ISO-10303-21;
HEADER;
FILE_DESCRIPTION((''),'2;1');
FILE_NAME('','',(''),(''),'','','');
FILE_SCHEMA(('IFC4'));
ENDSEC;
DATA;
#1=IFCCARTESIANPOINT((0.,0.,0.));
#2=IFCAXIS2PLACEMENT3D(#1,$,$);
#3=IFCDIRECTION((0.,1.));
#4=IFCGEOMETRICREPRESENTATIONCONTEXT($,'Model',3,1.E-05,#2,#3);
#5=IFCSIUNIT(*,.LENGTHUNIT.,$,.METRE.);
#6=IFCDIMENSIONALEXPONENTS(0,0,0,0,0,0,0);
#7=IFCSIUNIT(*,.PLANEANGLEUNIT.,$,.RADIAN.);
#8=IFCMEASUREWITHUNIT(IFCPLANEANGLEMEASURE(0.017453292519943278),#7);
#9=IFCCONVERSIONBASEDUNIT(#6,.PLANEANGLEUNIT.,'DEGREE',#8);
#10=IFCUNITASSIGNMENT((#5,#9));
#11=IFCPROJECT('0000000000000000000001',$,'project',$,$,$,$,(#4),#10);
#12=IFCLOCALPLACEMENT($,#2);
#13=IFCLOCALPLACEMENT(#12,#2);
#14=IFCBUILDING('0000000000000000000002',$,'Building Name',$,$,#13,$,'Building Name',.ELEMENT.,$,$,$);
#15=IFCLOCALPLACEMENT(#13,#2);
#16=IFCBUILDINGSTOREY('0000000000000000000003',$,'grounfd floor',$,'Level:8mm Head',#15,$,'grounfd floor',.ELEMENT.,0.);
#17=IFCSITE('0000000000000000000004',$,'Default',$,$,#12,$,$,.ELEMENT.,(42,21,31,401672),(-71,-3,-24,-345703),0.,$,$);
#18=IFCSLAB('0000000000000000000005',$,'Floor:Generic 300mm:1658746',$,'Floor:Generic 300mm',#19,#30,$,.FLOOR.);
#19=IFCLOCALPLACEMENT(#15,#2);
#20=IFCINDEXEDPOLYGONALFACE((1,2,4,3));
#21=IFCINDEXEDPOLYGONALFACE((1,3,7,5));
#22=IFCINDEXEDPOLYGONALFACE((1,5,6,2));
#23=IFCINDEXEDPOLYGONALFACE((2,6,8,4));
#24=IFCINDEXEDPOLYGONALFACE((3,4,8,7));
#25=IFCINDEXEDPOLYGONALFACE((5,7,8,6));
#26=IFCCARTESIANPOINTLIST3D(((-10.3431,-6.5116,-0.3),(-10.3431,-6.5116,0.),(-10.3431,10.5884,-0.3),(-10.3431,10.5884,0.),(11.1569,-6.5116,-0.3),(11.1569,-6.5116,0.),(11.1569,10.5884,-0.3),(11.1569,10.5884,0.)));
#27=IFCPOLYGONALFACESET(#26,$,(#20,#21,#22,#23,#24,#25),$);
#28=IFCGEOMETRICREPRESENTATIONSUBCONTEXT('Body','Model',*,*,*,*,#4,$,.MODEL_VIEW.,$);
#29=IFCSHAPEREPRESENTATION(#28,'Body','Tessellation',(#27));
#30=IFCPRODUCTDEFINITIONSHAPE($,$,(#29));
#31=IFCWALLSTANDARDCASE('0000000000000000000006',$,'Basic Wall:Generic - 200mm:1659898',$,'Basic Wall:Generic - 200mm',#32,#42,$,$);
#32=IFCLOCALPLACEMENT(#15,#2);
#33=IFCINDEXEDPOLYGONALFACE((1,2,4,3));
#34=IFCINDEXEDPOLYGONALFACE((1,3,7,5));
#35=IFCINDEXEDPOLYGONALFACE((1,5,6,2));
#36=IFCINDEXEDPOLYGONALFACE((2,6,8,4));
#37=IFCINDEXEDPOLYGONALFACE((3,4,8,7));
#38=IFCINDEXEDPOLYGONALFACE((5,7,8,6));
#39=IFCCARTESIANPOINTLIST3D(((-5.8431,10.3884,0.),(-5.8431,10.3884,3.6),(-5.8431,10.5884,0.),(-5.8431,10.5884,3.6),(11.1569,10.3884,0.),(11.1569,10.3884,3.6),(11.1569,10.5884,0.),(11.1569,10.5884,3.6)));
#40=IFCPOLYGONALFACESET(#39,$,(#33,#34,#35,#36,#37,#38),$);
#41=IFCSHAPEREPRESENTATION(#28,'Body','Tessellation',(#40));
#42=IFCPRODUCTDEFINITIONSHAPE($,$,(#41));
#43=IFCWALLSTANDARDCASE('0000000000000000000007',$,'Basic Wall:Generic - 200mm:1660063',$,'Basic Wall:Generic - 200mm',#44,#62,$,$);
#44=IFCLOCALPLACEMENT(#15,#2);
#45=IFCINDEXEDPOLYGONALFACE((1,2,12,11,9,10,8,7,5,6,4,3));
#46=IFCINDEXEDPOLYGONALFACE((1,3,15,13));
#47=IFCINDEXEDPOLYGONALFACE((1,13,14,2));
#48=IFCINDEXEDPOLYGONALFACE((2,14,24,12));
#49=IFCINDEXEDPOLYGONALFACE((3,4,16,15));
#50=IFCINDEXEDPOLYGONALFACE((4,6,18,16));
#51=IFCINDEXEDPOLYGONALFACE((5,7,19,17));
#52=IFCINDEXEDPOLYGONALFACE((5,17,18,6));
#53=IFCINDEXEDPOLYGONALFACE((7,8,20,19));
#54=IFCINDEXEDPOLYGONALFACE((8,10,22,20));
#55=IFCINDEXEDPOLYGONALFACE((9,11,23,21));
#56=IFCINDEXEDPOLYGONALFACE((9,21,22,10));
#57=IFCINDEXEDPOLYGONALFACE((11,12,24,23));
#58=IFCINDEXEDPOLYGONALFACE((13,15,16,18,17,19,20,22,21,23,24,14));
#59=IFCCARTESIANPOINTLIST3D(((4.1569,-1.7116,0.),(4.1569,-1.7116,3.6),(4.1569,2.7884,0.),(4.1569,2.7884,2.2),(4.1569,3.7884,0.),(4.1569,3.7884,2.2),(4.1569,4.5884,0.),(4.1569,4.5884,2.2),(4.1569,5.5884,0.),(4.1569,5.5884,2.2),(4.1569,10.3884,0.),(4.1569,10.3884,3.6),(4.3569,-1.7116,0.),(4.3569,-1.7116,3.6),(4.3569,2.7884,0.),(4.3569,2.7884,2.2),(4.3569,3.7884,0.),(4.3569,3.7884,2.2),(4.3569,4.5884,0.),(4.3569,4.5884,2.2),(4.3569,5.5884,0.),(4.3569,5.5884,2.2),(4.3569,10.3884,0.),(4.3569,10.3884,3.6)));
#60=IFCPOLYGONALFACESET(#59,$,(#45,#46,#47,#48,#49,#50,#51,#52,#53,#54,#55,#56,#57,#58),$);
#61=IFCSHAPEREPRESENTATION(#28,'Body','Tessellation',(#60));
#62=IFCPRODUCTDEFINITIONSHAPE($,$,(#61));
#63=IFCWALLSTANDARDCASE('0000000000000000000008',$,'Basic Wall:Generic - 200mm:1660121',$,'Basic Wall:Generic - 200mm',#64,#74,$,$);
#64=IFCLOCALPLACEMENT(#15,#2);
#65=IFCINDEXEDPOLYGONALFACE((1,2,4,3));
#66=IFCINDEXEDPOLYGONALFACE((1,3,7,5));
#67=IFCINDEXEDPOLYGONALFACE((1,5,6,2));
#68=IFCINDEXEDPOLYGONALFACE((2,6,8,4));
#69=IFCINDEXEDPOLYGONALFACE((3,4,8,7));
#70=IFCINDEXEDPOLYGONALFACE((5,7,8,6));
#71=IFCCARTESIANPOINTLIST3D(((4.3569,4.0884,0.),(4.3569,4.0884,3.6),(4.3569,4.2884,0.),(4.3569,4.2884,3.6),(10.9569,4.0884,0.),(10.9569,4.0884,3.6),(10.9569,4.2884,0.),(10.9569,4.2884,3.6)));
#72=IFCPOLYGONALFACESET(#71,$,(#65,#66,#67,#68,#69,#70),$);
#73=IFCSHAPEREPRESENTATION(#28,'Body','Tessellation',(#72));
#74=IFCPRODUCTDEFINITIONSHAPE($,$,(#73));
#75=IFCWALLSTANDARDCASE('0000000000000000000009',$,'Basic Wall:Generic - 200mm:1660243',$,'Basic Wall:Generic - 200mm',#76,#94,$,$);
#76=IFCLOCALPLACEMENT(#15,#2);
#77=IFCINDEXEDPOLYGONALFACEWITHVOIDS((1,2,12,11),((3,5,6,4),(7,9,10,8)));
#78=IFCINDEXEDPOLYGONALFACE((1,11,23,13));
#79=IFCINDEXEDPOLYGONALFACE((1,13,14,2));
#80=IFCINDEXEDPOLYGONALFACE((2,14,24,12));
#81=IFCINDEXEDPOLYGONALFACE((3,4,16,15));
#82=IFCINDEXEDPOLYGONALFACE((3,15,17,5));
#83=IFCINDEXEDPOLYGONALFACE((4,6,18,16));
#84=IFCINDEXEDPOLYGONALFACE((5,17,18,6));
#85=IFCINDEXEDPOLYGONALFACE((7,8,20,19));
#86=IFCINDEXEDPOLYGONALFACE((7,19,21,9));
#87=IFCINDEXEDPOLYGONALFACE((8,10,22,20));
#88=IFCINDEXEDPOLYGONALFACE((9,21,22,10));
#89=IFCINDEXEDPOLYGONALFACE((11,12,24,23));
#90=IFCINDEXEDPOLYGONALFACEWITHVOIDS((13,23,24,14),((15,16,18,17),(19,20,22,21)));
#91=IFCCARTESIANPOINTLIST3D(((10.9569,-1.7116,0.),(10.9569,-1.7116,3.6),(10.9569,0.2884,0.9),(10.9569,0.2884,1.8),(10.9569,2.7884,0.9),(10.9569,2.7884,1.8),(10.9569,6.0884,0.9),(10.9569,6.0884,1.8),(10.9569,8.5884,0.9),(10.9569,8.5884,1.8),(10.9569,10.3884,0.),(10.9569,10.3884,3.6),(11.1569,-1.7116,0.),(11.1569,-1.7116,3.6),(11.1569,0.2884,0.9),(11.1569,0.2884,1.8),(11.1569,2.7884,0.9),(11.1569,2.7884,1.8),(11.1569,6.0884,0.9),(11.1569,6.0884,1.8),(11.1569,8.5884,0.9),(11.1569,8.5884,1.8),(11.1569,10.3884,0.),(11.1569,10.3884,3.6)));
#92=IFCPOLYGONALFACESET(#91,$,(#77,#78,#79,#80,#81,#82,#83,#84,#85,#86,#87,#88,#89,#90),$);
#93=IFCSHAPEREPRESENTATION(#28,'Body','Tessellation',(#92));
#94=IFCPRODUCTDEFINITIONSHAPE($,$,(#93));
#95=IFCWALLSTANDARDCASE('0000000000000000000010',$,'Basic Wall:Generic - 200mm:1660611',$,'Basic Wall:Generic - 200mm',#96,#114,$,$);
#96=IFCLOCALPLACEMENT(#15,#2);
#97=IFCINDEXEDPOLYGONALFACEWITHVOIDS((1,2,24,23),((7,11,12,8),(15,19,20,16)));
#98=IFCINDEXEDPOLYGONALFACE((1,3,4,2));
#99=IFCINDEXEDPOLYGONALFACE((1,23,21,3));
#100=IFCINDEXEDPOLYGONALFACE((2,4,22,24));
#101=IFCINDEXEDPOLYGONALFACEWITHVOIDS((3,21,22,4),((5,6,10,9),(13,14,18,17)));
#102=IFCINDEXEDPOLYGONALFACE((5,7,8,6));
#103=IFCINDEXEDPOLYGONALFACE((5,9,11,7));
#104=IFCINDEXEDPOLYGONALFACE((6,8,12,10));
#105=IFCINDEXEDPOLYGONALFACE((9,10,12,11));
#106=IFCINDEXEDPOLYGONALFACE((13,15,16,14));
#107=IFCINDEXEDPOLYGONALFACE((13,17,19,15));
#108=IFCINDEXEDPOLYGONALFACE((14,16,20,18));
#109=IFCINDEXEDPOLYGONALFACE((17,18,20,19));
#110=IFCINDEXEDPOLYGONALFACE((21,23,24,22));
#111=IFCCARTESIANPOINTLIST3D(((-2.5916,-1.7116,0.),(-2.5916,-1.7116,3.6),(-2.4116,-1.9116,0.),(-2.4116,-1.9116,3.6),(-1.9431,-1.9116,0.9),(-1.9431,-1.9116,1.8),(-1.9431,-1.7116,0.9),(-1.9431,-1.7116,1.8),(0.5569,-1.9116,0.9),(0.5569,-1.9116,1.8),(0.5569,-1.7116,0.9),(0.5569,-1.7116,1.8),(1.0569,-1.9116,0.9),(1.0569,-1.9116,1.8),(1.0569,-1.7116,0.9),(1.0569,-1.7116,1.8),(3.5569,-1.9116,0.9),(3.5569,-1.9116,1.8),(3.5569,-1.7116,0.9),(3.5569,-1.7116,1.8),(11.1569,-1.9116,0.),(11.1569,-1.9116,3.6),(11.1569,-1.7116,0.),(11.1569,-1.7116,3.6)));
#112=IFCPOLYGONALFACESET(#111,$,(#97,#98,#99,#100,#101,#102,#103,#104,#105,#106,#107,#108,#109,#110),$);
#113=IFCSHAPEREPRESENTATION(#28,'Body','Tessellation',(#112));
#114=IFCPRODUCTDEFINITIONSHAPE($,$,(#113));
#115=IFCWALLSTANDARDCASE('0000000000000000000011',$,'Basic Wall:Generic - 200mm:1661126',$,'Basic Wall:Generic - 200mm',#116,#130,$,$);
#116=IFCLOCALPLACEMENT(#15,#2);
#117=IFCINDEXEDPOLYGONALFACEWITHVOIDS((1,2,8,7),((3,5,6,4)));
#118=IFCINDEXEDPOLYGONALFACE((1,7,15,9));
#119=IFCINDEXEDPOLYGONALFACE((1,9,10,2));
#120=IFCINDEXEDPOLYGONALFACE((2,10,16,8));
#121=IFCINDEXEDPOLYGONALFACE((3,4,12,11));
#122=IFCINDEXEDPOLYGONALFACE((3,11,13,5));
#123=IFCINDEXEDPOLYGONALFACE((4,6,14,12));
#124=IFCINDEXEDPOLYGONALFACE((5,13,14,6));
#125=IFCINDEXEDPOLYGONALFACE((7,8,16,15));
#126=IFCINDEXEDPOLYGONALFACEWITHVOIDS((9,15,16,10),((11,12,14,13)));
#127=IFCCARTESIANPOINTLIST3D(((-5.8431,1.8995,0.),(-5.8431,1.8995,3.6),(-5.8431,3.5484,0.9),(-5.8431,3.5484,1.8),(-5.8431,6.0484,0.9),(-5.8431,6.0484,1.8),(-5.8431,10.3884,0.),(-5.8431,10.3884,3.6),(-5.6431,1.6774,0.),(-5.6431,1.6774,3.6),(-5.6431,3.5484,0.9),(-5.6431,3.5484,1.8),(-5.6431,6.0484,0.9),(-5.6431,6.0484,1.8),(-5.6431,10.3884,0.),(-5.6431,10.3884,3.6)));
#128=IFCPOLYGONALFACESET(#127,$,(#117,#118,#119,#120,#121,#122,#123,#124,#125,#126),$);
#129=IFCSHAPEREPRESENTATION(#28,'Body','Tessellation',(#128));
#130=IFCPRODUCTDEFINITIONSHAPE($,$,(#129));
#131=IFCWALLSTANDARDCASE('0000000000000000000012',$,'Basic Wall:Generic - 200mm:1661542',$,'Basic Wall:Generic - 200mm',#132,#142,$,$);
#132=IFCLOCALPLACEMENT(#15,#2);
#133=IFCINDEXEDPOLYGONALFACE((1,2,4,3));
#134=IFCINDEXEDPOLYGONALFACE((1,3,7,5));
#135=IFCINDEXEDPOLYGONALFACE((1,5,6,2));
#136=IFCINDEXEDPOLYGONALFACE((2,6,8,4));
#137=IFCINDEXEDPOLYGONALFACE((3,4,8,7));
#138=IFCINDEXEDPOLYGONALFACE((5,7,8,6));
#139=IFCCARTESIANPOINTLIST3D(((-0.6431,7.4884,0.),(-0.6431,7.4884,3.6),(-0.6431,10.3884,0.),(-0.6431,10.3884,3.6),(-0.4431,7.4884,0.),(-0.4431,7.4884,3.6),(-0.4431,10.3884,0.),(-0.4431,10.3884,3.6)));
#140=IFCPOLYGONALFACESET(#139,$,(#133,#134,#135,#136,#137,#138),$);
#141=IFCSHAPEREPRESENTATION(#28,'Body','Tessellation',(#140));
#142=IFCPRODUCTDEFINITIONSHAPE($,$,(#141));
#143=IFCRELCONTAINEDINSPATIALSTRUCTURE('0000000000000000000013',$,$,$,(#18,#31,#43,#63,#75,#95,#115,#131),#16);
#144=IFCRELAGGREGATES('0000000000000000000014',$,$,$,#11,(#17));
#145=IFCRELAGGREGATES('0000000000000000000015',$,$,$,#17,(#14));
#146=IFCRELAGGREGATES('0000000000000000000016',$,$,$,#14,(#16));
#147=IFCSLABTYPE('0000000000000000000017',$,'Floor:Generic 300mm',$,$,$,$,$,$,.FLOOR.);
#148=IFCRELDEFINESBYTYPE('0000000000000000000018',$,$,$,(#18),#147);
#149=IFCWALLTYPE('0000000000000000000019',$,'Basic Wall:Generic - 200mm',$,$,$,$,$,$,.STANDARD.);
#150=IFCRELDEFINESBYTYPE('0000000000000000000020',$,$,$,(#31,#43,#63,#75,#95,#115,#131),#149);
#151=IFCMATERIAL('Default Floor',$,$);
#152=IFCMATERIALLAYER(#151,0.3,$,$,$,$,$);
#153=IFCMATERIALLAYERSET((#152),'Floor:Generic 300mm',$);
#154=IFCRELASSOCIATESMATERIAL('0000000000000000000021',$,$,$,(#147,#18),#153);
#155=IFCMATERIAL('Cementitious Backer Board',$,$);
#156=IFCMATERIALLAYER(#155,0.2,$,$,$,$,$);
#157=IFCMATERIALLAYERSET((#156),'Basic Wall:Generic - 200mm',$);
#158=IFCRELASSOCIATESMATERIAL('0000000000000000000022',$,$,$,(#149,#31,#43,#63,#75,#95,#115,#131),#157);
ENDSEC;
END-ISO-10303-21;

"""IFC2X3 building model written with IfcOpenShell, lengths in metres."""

from ifc_helpers import new_model, entity, si_unit, converted_unit, direction, frame, frame_2d, origin, place, context, subcontext, project, spatial, polyline, rectangle, outline, extrude, material, layer, layer_set, layer_usage, type_object, element, save


model = new_model("IFC2X3")

# Units and contexts
model_context = context("Model", 3, precision=1e-05, world=origin(), true_north=direction((0.0, 1.0)))
body_context = subcontext(model_context, "Body", "Model", "MODEL_VIEW")
ifc_project = project(units=[si_unit("LENGTHUNIT", "METRE"), converted_unit("PLANEANGLEUNIT", "DEGREE", entity("IfcPlaneAngleMeasure", 0.017453292519943278), si_unit("PLANEANGLEUNIT", "RADIAN"), dimensions=[0, 0, 0, 0, 0, 0, 0])], contexts=[model_context])

# Site, building, storey
site_placement = place(None, origin())
site = spatial("IfcSite", under=ifc_project, at=site_placement, Name="Default", CompositionType="ELEMENT", RefLatitude=(42, 21, 31, 401672), RefLongitude=(-71, -3, -24, -345703), RefElevation=0.0)
building_placement = place(site_placement, origin())
building = spatial("IfcBuilding", under=site, at=building_placement, Name="Building Name", LongName="Building Name", CompositionType="ELEMENT")
storey_placement = place(building_placement, origin())
storey = spatial("IfcBuildingStorey", under=building, at=storey_placement, Name="grounfd floor", ObjectType="Level:8mm Head", LongName="grounfd floor", CompositionType="ELEMENT", Elevation=0.0)

# Slab
ifc_material_1 = material(Name="Default Floor")
ifc_layer_1 = layer(ifc_material_1, 0.3)
ifc_layer_set_1 = layer_set([ifc_layer_1], Name="Floor:Generic 300mm")
ifc_layer_usage_1 = layer_usage(ifc_layer_set_1, "AXIS3", "POSITIVE", 0.0)
slab_type = type_object("IfcSlabType", Name="Floor:Generic 300mm", PredefinedType="FLOOR", material=ifc_layer_set_1)
slab_placement = place(storey_placement, origin())
element("IfcSlab", 1, at=slab_placement, inside=storey, type_object=slab_type, material=ifc_layer_usage_1, Name="Floor:Generic 300mm:1658746", ObjectType="Floor:Generic 300mm", PredefinedType="FLOOR", context=body_context, shape_type="SweptSolid", body=[
    extrude(rectangle(XDim=17.1, YDim=21.5, at=frame_2d((0.0, 0.0), x_axis=(1.0, 0.0))), frame((0.4069, 2.0384, 0.0), z_axis=(0.0, 0.0, -1.0), x_axis=(0.0, 1.0, 0.0)), (0.0, 0.0, 1.0), 0.3),
])

# Wall
ifc_material_2 = material(Name="Cementitious Backer Board")
ifc_layer_2 = layer(ifc_material_2, 0.2)
ifc_layer_set_2 = layer_set([ifc_layer_2], Name="Basic Wall:Generic - 200mm")
ifc_layer_usage_2 = layer_usage(ifc_layer_set_2, "AXIS2", "NEGATIVE", 0.1)
wall_type = type_object("IfcWallType", Name="Basic Wall:Generic - 200mm", PredefinedType="STANDARD", material=ifc_layer_set_2)
wall_1_placement = place(storey_placement, frame((11.1569, 10.4884, 0.0), z_axis=(0.0, 0.0, 1.0), x_axis=(-1.0, 0.0, 0.0)))
element("IfcWallStandardCase", 2, at=wall_1_placement, inside=storey, type_object=wall_type, material=ifc_layer_usage_2, Name="Basic Wall:Generic - 200mm:1659898", ObjectType="Basic Wall:Generic - 200mm", context=body_context, shape_type="SweptSolid", body=[
    extrude(rectangle(XDim=17.0, YDim=0.2, at=frame_2d((8.5, 0.0), x_axis=(-1.0, 0.0))), origin(), (0.0, 0.0, 1.0), 3.6),
])

# Wall, openings
ifc_layer_usage_3 = layer_usage(ifc_layer_set_2, "AXIS2", "NEGATIVE", 0.1)
wall_2_placement = place(storey_placement, frame((4.2569, 10.3884, 0.0), z_axis=(0.0, 0.0, 1.0), x_axis=(0.0, -1.0, 0.0)))
wall_2 = element("IfcWallStandardCase", 3, at=wall_2_placement, inside=storey, type_object=wall_type, material=ifc_layer_usage_3, Name="Basic Wall:Generic - 200mm:1660063", ObjectType="Basic Wall:Generic - 200mm", context=body_context, shape_type="SweptSolid", body=[
    extrude(rectangle(XDim=12.1, YDim=0.2, at=frame_2d((6.05, 0.0), x_axis=(-1.0, 0.0))), origin(), (0.0, 0.0, 1.0), 3.6),
])
opening_1_placement = place(wall_2_placement, frame((4.8, -0.1, 0.0)))
element("IfcOpeningElement", 4, at=opening_1_placement, cuts=wall_2, ObjectType="Opening", context=body_context, shape_type="SweptSolid", body=[
    extrude(rectangle(XDim=2.2, YDim=1.0, at=frame_2d((1.1, 0.5), x_axis=(1.0, 0.0))), frame((0.0, 0.0, 0.0), z_axis=(0.0, 1.0, 0.0), x_axis=(0.0, 0.0, 1.0)), (0.0, 0.0, 1.0), 0.2),
])
opening_2_placement = place(wall_2_placement, frame((6.6, -0.1, 0.0)))
element("IfcOpeningElement", 5, at=opening_2_placement, cuts=wall_2, ObjectType="Opening", context=body_context, shape_type="SweptSolid", body=[
    extrude(rectangle(XDim=2.2, YDim=1.0, at=frame_2d((1.1, 0.5), x_axis=(1.0, 0.0))), frame((0.0, 0.0, 0.0), z_axis=(0.0, 1.0, 0.0), x_axis=(0.0, 0.0, 1.0)), (0.0, 0.0, 1.0), 0.2),
])

# Wall
ifc_layer_usage_4 = layer_usage(ifc_layer_set_2, "AXIS2", "NEGATIVE", 0.1)
wall_3_placement = place(storey_placement, frame((4.3569, 4.1884, 0.0)))
element("IfcWallStandardCase", 6, at=wall_3_placement, inside=storey, type_object=wall_type, material=ifc_layer_usage_4, Name="Basic Wall:Generic - 200mm:1660121", ObjectType="Basic Wall:Generic - 200mm", context=body_context, shape_type="SweptSolid", body=[
    extrude(rectangle(XDim=6.6, YDim=0.2, at=frame_2d((3.3, 0.0), x_axis=(-1.0, 0.0))), origin(), (0.0, 0.0, 1.0), 3.6),
])

# Walls, openings
ifc_layer_usage_5 = layer_usage(ifc_layer_set_2, "AXIS2", "NEGATIVE", 0.1)
wall_4_placement = place(storey_placement, frame((11.0569, -1.7116, 0.0), z_axis=(0.0, 0.0, 1.0), x_axis=(0.0, 1.0, 0.0)))
wall_4 = element("IfcWallStandardCase", 7, at=wall_4_placement, inside=storey, type_object=wall_type, material=ifc_layer_usage_5, Name="Basic Wall:Generic - 200mm:1660243", ObjectType="Basic Wall:Generic - 200mm", context=body_context, shape_type="SweptSolid", body=[
    extrude(rectangle(XDim=12.1, YDim=0.2, at=frame_2d((6.05, 0.0), x_axis=(-1.0, 0.0))), origin(), (0.0, 0.0, 1.0), 3.6),
])
opening_3_placement = place(wall_4_placement, frame((10.3, 0.1, 0.9)))
element("IfcOpeningElement", 8, at=opening_3_placement, cuts=wall_4, ObjectType="Opening", context=body_context, shape_type="SweptSolid", body=[
    extrude(rectangle(XDim=0.9, YDim=2.5, at=frame_2d((0.45, 1.25), x_axis=(-1.0, 0.0))), frame((0.0, 0.0, 0.0), z_axis=(0.0, -1.0, 0.0), x_axis=(0.0, 0.0, 1.0)), (0.0, 0.0, 1.0), 0.2),
])
opening_4_placement = place(wall_4_placement, frame((4.5, 0.1, 0.9)))
element("IfcOpeningElement", 9, at=opening_4_placement, cuts=wall_4, ObjectType="Opening", context=body_context, shape_type="SweptSolid", body=[
    extrude(rectangle(XDim=0.9, YDim=2.5, at=frame_2d((0.45, 1.25), x_axis=(-1.0, 0.0))), frame((0.0, 0.0, 0.0), z_axis=(0.0, -1.0, 0.0), x_axis=(0.0, 0.0, 1.0)), (0.0, 0.0, 1.0), 0.2),
])
ifc_layer_usage_6 = layer_usage(ifc_layer_set_2, "AXIS2", "NEGATIVE", 0.1)
wall_5_placement = place(storey_placement, frame((-2.5916, -1.8116, 0.0)))
wall_5 = element("IfcWallStandardCase", 10, at=wall_5_placement, inside=storey, type_object=wall_type, material=ifc_layer_usage_6, Name="Basic Wall:Generic - 200mm:1660611", ObjectType="Basic Wall:Generic - 200mm", context=body_context, shape_type="SweptSolid", body=[
    extrude(outline(polyline([(13.7486, -0.1), (13.7486, 0.1), (13.5486, 0.1), (6.9486, 0.1), (6.7486, 0.1), (0.2691, 0.1), (0.0, 0.1), (0.1801, -0.1), (13.7486, -0.1)])), origin(), (0.0, 0.0, 1.0), 3.6),
])
opening_5_placement = place(wall_5_placement, frame((6.1486, 0.1, 0.9)))
element("IfcOpeningElement", 11, at=opening_5_placement, cuts=wall_5, ObjectType="Opening", context=body_context, shape_type="SweptSolid", body=[
    extrude(rectangle(XDim=0.9, YDim=2.5, at=frame_2d((0.45, 1.25), x_axis=(-1.0, 0.0))), frame((0.0, 0.0, 0.0), z_axis=(0.0, -1.0, 0.0), x_axis=(0.0, 0.0, 1.0)), (0.0, 0.0, 1.0), 0.2),
])
opening_6_placement = place(wall_5_placement, frame((3.1486, 0.1, 0.9)))
element("IfcOpeningElement", 12, at=opening_6_placement, cuts=wall_5, ObjectType="Opening", context=body_context, shape_type="SweptSolid", body=[
    extrude(rectangle(XDim=0.9, YDim=2.5, at=frame_2d((0.45, 1.25), x_axis=(-1.0, 0.0))), frame((0.0, 0.0, 0.0), z_axis=(0.0, -1.0, 0.0), x_axis=(0.0, 0.0, 1.0)), (0.0, 0.0, 1.0), 0.2),
])

# Wall, opening
ifc_layer_usage_7 = layer_usage(ifc_layer_set_2, "AXIS2", "NEGATIVE", 0.1)
wall_6_placement = place(storey_placement, frame((-5.7431, 10.3884, 0.0), z_axis=(0.0, 0.0, 1.0), x_axis=(0.0, -1.0, 0.0)))
wall_6 = element("IfcWallStandardCase", 13, at=wall_6_placement, inside=storey, type_object=wall_type, material=ifc_layer_usage_7, Name="Basic Wall:Generic - 200mm:1661126", ObjectType="Basic Wall:Generic - 200mm", context=body_context, shape_type="SweptSolid", body=[
    extrude(outline(polyline([(8.4889, -0.1), (8.7111, 0.1), (8.4122, 0.1), (0.0, 0.1), (0.0, -0.1), (8.4889, -0.1)])), origin(), (0.0, 0.0, 1.0), 3.6),
])
opening_7_placement = place(wall_6_placement, frame((4.34, -0.1, 0.9)))
element("IfcOpeningElement", 14, at=opening_7_placement, cuts=wall_6, ObjectType="Opening", context=body_context, shape_type="SweptSolid", body=[
    extrude(rectangle(XDim=0.9, YDim=2.5, at=frame_2d((0.45, 1.25), x_axis=(-1.0, 0.0))), frame((0.0, 0.0, 0.0), z_axis=(0.0, 1.0, 0.0), x_axis=(0.0, 0.0, 1.0)), (0.0, 0.0, 1.0), 0.2),
])

# Wall
ifc_layer_usage_8 = layer_usage(ifc_layer_set_2, "AXIS2", "NEGATIVE", 0.1)
wall_7_placement = place(storey_placement, frame((-0.5431, 10.3884, 0.0), z_axis=(0.0, 0.0, 1.0), x_axis=(0.0, -1.0, 0.0)))
element("IfcWallStandardCase", 15, at=wall_7_placement, inside=storey, type_object=wall_type, material=ifc_layer_usage_8, Name="Basic Wall:Generic - 200mm:1661542", ObjectType="Basic Wall:Generic - 200mm", context=body_context, shape_type="SweptSolid", body=[
    extrude(rectangle(XDim=2.9, YDim=0.2, at=frame_2d((1.45, 0.0), x_axis=(-1.0, 0.0))), origin(), (0.0, 0.0, 1.0), 3.6),
])

save(model, "model.ifc")
